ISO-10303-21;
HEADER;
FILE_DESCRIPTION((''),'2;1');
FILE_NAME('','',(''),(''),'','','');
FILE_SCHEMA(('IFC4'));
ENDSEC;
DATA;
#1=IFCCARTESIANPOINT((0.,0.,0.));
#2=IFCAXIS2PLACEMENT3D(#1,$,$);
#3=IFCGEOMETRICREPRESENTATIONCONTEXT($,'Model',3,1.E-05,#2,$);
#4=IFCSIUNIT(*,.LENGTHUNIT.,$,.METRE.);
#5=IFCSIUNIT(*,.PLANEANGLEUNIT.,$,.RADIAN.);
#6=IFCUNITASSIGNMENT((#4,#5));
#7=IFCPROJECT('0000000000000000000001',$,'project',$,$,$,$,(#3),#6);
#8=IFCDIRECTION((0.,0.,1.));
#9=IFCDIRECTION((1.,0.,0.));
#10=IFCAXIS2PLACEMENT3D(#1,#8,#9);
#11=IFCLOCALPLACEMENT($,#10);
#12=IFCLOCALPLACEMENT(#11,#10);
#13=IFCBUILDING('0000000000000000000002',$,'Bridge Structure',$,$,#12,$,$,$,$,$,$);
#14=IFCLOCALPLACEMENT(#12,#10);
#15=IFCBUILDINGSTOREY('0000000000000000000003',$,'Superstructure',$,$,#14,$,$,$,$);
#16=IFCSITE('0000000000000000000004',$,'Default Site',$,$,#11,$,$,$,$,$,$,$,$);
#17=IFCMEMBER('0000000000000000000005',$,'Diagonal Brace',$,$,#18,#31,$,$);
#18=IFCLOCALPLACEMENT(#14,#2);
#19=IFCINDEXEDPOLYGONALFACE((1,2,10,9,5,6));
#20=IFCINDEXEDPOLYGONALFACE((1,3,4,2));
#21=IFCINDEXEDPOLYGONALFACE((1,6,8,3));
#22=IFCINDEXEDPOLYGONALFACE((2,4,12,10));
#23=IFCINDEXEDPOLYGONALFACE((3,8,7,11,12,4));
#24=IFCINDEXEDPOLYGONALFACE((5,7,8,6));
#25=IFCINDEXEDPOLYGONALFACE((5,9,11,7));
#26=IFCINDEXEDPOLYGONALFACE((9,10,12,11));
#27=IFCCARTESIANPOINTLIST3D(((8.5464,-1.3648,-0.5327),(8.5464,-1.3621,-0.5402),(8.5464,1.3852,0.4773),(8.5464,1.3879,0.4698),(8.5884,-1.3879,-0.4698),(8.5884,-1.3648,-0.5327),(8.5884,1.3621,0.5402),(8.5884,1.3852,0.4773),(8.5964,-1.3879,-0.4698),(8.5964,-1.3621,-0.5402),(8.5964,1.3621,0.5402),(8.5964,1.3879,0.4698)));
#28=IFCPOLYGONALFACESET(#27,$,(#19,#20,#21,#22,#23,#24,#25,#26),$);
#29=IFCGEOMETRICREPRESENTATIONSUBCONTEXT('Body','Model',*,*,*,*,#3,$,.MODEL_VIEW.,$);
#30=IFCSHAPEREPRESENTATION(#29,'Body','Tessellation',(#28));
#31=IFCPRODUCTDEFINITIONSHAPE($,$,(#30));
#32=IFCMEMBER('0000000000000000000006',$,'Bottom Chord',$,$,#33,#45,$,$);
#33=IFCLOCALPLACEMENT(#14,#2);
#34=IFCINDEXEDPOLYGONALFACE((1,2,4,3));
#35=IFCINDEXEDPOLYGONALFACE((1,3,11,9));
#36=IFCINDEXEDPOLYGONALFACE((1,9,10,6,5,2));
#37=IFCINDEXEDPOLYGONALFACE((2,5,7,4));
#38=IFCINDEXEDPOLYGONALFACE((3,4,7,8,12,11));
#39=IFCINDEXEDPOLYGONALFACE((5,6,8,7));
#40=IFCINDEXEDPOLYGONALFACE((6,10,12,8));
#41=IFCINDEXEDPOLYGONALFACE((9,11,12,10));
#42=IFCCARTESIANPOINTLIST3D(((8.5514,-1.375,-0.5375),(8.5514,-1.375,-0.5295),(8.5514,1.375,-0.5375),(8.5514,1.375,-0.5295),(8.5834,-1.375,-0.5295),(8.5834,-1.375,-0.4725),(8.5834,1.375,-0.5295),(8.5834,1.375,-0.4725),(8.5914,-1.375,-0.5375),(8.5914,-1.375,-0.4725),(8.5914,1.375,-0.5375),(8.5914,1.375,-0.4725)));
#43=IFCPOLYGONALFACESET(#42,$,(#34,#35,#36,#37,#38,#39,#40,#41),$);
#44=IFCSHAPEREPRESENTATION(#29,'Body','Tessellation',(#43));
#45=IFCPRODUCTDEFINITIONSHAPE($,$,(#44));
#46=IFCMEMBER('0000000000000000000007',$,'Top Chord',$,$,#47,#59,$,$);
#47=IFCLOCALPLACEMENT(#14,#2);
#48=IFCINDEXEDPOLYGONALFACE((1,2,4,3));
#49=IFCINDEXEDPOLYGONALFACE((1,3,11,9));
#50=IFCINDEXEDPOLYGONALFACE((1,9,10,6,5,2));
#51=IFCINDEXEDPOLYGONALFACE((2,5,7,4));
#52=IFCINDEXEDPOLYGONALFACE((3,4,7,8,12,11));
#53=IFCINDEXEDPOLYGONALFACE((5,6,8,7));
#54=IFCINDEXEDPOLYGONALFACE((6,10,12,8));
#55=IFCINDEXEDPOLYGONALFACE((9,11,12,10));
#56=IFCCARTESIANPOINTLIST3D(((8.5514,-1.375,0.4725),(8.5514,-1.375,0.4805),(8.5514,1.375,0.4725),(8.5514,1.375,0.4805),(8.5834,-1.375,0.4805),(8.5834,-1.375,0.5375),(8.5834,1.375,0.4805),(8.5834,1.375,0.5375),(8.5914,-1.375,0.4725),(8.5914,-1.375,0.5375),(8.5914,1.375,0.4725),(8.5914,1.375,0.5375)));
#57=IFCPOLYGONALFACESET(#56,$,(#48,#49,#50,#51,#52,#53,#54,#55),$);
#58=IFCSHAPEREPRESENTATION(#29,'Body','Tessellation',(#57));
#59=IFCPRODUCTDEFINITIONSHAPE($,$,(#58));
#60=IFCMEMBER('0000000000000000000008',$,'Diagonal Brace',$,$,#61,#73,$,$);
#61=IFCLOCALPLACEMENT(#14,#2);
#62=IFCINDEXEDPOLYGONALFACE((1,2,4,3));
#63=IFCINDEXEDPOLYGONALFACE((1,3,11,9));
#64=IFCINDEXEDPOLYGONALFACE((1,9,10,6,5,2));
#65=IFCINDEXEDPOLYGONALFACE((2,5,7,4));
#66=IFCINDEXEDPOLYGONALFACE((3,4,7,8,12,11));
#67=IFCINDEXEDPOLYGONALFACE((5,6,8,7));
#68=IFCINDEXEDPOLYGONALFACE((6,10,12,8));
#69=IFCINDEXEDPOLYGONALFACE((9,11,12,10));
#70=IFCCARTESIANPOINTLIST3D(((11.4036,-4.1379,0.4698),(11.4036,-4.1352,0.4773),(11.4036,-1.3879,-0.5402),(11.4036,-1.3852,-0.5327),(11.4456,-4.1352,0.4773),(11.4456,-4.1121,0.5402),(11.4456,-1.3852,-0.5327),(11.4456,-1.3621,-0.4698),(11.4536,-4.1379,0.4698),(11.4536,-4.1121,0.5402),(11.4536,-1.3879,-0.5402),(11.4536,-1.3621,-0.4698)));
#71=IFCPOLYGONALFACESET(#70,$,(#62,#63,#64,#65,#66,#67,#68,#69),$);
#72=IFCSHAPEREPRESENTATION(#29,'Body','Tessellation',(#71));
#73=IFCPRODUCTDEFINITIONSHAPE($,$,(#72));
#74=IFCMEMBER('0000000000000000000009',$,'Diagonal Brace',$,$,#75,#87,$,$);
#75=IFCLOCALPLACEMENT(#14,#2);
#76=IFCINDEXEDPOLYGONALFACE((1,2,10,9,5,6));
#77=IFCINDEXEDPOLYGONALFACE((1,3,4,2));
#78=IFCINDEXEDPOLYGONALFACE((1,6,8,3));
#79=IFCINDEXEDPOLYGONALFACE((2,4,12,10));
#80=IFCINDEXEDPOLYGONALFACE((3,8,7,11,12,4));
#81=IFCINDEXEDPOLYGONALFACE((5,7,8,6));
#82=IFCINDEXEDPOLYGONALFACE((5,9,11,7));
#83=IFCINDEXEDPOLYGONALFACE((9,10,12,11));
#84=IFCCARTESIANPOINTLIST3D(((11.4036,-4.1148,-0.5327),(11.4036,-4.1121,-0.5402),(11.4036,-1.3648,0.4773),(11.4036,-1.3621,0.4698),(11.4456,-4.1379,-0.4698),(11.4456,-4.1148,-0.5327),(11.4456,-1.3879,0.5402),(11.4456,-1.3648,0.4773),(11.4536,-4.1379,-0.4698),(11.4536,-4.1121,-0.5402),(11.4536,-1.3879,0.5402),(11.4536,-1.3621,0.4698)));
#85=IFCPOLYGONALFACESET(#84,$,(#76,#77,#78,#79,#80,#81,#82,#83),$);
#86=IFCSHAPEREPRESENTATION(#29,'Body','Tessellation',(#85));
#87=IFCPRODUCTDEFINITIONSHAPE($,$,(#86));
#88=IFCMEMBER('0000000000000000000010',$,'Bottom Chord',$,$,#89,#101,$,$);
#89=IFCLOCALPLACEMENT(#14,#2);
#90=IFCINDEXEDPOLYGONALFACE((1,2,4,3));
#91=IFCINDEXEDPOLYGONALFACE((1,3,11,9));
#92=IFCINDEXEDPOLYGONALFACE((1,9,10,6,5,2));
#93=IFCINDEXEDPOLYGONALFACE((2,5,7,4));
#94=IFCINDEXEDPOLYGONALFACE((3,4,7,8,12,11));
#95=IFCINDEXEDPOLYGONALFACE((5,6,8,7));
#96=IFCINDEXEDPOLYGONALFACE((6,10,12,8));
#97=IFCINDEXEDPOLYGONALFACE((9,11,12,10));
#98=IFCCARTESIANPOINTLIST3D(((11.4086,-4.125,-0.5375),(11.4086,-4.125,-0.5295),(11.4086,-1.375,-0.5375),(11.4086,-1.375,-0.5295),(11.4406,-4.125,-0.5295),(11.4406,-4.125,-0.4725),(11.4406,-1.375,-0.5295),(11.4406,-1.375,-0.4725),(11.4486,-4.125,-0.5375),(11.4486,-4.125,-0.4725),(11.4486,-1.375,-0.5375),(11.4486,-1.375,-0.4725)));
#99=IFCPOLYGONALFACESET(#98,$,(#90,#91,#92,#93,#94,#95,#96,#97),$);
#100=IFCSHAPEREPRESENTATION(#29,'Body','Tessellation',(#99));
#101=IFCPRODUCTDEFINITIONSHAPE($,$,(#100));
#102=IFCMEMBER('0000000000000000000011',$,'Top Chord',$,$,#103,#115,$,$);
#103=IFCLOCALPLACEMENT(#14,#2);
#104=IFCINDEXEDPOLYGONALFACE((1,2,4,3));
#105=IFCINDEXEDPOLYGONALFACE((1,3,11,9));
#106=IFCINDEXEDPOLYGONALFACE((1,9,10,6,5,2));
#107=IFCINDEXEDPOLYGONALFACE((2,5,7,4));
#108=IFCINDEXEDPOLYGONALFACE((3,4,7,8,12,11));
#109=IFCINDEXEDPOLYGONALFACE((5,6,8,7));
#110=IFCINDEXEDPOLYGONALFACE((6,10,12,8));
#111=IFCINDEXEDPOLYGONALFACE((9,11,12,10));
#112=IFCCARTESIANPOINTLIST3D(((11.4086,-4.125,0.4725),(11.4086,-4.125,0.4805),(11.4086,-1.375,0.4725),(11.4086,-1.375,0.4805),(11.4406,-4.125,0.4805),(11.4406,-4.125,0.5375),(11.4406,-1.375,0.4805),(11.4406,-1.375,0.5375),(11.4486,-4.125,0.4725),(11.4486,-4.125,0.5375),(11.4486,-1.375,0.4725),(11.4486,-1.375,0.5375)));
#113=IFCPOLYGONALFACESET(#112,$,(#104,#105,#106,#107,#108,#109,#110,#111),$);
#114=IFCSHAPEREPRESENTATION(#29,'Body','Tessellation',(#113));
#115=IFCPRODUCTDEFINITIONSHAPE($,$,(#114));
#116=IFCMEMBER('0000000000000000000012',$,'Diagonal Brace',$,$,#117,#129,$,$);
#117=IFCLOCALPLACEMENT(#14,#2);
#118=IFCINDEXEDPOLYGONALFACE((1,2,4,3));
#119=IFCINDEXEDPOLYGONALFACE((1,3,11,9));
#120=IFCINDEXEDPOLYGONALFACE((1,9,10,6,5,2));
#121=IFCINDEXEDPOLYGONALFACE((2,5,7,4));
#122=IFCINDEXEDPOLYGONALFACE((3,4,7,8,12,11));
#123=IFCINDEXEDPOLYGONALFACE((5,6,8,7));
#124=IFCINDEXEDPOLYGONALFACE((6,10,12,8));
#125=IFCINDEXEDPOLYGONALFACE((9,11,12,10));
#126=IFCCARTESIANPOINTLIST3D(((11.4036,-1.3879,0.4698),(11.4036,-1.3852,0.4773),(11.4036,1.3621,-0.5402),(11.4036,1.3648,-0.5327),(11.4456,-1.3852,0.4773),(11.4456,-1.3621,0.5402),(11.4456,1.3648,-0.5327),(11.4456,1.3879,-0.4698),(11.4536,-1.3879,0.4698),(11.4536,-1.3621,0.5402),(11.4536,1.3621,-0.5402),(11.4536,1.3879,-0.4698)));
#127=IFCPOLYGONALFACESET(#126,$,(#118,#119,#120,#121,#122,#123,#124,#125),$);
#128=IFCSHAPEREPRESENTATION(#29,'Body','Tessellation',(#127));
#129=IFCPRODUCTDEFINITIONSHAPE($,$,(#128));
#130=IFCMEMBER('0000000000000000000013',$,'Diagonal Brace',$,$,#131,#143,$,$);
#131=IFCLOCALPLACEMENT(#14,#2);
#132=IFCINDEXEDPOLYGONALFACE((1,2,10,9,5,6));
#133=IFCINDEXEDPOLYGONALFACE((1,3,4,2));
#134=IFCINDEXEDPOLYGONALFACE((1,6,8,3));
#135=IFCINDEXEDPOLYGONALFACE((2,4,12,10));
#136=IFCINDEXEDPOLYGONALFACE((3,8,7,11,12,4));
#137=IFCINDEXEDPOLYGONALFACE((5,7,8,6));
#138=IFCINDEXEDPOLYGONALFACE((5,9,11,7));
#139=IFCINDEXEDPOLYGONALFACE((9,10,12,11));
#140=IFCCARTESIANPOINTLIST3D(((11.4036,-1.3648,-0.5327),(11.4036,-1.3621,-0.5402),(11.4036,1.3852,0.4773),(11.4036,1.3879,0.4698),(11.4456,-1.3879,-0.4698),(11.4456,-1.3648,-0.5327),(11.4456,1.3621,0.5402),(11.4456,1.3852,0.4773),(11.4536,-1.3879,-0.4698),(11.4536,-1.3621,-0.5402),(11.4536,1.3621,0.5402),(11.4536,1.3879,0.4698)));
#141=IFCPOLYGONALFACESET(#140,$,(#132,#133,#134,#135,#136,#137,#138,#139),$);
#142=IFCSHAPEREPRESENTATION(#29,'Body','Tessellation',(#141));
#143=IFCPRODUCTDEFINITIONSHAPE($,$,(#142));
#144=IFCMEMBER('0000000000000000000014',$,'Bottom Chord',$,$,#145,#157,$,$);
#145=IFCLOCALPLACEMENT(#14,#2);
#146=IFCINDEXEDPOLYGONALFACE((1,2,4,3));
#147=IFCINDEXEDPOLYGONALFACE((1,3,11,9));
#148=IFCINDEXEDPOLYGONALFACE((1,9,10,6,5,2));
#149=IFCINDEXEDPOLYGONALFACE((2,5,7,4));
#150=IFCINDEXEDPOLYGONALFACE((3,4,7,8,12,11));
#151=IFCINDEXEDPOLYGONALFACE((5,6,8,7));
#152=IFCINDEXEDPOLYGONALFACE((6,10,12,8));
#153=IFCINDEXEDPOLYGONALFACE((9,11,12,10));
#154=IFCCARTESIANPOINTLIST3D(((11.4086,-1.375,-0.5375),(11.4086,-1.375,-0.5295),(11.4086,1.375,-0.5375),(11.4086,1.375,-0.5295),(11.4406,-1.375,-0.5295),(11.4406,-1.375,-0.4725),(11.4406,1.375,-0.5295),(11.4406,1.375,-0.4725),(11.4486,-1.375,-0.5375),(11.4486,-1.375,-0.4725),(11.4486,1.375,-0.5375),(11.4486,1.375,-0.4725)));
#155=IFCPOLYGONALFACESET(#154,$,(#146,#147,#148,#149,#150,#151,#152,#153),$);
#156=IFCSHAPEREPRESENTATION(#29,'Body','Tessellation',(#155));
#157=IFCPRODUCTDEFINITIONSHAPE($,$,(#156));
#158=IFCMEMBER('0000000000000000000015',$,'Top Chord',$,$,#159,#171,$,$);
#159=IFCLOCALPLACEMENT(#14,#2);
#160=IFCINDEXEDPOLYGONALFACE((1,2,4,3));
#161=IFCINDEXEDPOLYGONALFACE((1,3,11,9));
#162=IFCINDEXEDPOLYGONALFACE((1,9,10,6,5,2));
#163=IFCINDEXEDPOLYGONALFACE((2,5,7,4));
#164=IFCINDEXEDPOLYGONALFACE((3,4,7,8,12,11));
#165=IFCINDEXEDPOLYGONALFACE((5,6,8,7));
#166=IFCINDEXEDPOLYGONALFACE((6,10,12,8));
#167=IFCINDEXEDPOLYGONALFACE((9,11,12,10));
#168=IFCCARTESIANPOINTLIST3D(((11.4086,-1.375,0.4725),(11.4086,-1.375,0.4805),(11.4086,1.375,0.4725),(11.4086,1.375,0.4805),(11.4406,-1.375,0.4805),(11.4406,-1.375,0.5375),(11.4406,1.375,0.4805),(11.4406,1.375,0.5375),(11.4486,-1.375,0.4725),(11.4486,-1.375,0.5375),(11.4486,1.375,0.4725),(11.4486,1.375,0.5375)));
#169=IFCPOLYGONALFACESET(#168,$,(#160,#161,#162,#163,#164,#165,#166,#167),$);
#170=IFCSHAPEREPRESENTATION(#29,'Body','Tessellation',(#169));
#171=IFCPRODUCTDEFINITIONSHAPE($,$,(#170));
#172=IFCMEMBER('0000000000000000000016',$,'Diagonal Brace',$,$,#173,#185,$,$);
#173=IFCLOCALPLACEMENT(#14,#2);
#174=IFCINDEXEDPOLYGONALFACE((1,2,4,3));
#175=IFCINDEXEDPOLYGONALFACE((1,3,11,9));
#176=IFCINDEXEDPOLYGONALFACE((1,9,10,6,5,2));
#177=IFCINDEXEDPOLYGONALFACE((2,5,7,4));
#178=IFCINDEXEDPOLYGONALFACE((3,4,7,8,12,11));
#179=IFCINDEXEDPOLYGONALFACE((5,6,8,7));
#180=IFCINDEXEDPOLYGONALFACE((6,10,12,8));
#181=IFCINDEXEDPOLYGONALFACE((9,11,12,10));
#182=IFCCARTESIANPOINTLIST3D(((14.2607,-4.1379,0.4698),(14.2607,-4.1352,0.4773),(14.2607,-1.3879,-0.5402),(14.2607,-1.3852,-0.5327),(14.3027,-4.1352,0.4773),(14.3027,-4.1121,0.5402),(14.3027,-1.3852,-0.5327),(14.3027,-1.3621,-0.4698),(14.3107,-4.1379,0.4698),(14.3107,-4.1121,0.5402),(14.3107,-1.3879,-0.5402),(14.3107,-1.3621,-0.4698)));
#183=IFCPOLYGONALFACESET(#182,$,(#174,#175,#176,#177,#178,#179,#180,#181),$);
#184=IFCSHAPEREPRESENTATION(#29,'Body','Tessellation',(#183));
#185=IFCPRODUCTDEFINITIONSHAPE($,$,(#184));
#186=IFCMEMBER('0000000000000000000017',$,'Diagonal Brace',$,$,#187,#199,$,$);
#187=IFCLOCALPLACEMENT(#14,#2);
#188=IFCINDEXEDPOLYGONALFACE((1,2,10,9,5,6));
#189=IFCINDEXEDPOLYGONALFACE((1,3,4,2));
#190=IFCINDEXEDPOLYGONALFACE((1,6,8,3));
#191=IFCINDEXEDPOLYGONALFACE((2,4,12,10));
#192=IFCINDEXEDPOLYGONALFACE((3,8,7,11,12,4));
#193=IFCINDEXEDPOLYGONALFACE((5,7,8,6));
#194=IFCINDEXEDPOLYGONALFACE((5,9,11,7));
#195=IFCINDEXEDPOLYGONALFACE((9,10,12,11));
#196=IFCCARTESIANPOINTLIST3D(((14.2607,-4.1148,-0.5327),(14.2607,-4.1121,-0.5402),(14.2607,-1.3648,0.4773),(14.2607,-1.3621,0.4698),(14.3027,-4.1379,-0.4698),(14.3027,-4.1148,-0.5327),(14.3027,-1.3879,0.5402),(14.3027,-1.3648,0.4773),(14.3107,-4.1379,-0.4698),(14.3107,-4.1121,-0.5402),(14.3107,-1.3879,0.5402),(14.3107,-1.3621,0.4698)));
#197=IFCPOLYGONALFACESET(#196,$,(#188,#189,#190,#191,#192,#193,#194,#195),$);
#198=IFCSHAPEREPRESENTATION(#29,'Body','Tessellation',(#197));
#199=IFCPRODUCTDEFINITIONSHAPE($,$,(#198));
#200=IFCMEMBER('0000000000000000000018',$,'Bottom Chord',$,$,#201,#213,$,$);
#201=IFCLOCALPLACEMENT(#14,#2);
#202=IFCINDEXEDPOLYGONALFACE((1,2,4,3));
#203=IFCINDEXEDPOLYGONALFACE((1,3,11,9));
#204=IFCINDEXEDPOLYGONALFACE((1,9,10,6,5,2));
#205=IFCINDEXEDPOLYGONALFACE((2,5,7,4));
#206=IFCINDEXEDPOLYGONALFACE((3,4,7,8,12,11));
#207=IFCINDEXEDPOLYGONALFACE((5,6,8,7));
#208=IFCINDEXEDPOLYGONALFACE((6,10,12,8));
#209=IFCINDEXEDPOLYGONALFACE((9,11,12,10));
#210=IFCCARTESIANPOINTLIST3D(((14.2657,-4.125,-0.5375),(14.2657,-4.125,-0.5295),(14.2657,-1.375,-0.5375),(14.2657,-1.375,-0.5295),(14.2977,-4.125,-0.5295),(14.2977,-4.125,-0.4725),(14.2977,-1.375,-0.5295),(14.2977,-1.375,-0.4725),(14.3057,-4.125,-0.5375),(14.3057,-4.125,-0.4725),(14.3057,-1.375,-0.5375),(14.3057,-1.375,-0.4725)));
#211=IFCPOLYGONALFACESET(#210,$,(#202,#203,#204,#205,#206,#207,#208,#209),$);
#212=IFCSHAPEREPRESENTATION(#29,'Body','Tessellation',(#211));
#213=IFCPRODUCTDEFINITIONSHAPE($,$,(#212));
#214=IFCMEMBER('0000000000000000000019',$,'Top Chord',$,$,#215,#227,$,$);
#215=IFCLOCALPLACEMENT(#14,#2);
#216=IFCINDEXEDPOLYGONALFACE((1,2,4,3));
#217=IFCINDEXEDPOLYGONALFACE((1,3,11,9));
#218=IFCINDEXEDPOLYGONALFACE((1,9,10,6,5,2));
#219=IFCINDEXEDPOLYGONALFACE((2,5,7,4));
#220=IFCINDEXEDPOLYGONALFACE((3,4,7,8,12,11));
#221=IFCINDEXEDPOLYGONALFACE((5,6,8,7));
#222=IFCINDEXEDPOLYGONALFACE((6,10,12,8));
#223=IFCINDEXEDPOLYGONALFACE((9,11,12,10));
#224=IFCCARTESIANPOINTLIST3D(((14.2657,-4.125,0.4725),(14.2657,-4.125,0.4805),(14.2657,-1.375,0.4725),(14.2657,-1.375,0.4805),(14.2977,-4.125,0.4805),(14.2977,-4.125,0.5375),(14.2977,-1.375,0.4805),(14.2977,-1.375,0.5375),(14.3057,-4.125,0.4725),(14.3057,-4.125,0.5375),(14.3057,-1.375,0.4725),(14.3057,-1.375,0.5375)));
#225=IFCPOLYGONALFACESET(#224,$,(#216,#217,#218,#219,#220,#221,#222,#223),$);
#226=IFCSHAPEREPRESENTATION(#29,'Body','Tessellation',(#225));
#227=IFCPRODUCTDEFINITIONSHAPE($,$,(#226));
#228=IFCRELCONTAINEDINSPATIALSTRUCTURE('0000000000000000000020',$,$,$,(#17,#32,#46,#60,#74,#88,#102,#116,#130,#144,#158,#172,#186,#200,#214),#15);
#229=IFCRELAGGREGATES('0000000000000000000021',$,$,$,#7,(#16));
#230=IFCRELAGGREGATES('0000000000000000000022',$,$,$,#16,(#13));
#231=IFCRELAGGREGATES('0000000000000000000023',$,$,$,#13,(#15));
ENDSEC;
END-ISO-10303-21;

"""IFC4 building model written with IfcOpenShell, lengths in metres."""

from ifc_helpers import new_model, si_unit, frame, origin, origin_with_axes, origin_2d_with_axis, place, context, subcontext, project, spatial, l_section, extrude, element, save


model = new_model("IFC4")

# Units and contexts
model_context = context("Model", 3, precision=1e-05, world=origin())
body_context = subcontext(model_context, "Body", "Model", "MODEL_VIEW")
ifc_project = project(units=[si_unit("LENGTHUNIT", "METRE"), si_unit("PLANEANGLEUNIT", "RADIAN")], contexts=[model_context])

# Site, building, storey
site_placement = place(None, origin_with_axes())
site = spatial("IfcSite", under=ifc_project, at=site_placement, Name="Default Site")
building_placement = place(site_placement, origin_with_axes())
building = spatial("IfcBuilding", under=site, at=building_placement, Name="Bridge Structure")
storey_placement = place(building_placement, origin_with_axes())
storey = spatial("IfcBuildingStorey", under=building, at=storey_placement, Name="Superstructure")

# Members
member_placement = place(storey_placement, frame((8.5714, -1.375, -0.505), z_axis=(0.0, 0.938692, 0.344756), x_axis=(-1.0, 0.0, 0.0)))
element("IfcMember", 1, at=member_placement, inside=storey, Name="Diagonal Brace", context=body_context, shape_type="SweptSolid", body=[
    extrude(l_section(Depth=0.075, Width=0.05, Thickness=0.008, at=origin_2d_with_axis()), origin_with_axes(), (0.0, 0.0, 1.0), 2.9296),
])
for number, where, z_axis, x_axis, name in (
    (2, (8.5714, -1.375, -0.505), (0.0, 1.0, 0.0), (-1.0, 0.0, 0.0), "Bottom Chord"),
    (3, (8.5714, -1.375, 0.505), (0.0, 1.0, 0.0), (-1.0, 0.0, 0.0), "Top Chord"),
):
    element("IfcMember", number, at=place(storey_placement, frame(where, z_axis=z_axis, x_axis=x_axis)), inside=storey, Name=name, context=body_context, shape_type="SweptSolid", body=[
        extrude(l_section(Depth=0.065, Width=0.04, Thickness=0.008, at=origin_2d_with_axis()), origin_with_axes(), (0.0, 0.0, 1.0), 2.75),
    ])
for number, where, z_axis, x_axis, name in (
    (4, (11.4286, -4.125, 0.505), (0.0, 0.938692, -0.344756), (-1.0, 0.0, 0.0), "Diagonal Brace"),
    (5, (11.4286, -4.125, -0.505), (0.0, 0.938692, 0.344756), (-1.0, 0.0, 0.0), "Diagonal Brace"),
):
    element("IfcMember", number, at=place(storey_placement, frame(where, z_axis=z_axis, x_axis=x_axis)), inside=storey, Name=name, context=body_context, shape_type="SweptSolid", body=[
        extrude(l_section(Depth=0.075, Width=0.05, Thickness=0.008, at=origin_2d_with_axis()), origin_with_axes(), (0.0, 0.0, 1.0), 2.9296),
    ])
for number, where, z_axis, x_axis, name in (
    (6, (11.4286, -4.125, -0.505), (0.0, 1.0, 0.0), (-1.0, 0.0, 0.0), "Bottom Chord"),
    (7, (11.4286, -4.125, 0.505), (0.0, 1.0, 0.0), (-1.0, 0.0, 0.0), "Top Chord"),
):
    element("IfcMember", number, at=place(storey_placement, frame(where, z_axis=z_axis, x_axis=x_axis)), inside=storey, Name=name, context=body_context, shape_type="SweptSolid", body=[
        extrude(l_section(Depth=0.065, Width=0.04, Thickness=0.008, at=origin_2d_with_axis()), origin_with_axes(), (0.0, 0.0, 1.0), 2.75),
    ])
for number, where, z_axis, x_axis, name in (
    (8, (11.4286, -1.375, 0.505), (0.0, 0.938692, -0.344756), (-1.0, 0.0, 0.0), "Diagonal Brace"),
    (9, (11.4286, -1.375, -0.505), (0.0, 0.938692, 0.344756), (-1.0, 0.0, 0.0), "Diagonal Brace"),
):
    element("IfcMember", number, at=place(storey_placement, frame(where, z_axis=z_axis, x_axis=x_axis)), inside=storey, Name=name, context=body_context, shape_type="SweptSolid", body=[
        extrude(l_section(Depth=0.075, Width=0.05, Thickness=0.008, at=origin_2d_with_axis()), origin_with_axes(), (0.0, 0.0, 1.0), 2.9296),
    ])
for number, where, z_axis, x_axis, name in (
    (10, (11.4286, -1.375, -0.505), (0.0, 1.0, 0.0), (-1.0, 0.0, 0.0), "Bottom Chord"),
    (11, (11.4286, -1.375, 0.505), (0.0, 1.0, 0.0), (-1.0, 0.0, 0.0), "Top Chord"),
):
    element("IfcMember", number, at=place(storey_placement, frame(where, z_axis=z_axis, x_axis=x_axis)), inside=storey, Name=name, context=body_context, shape_type="SweptSolid", body=[
        extrude(l_section(Depth=0.065, Width=0.04, Thickness=0.008, at=origin_2d_with_axis()), origin_with_axes(), (0.0, 0.0, 1.0), 2.75),
    ])
for number, where, z_axis, x_axis, name in (
    (12, (14.2857, -4.125, 0.505), (0.0, 0.938692, -0.344756), (-1.0, 0.0, 0.0), "Diagonal Brace"),
    (13, (14.2857, -4.125, -0.505), (0.0, 0.938692, 0.344756), (-1.0, 0.0, 0.0), "Diagonal Brace"),
):
    element("IfcMember", number, at=place(storey_placement, frame(where, z_axis=z_axis, x_axis=x_axis)), inside=storey, Name=name, context=body_context, shape_type="SweptSolid", body=[
        extrude(l_section(Depth=0.075, Width=0.05, Thickness=0.008, at=origin_2d_with_axis()), origin_with_axes(), (0.0, 0.0, 1.0), 2.9296),
    ])
for number, where, z_axis, x_axis, name in (
    (14, (14.2857, -4.125, -0.505), (0.0, 1.0, 0.0), (-1.0, 0.0, 0.0), "Bottom Chord"),
    (15, (14.2857, -4.125, 0.505), (0.0, 1.0, 0.0), (-1.0, 0.0, 0.0), "Top Chord"),
):
    element("IfcMember", number, at=place(storey_placement, frame(where, z_axis=z_axis, x_axis=x_axis)), inside=storey, Name=name, context=body_context, shape_type="SweptSolid", body=[
        extrude(l_section(Depth=0.065, Width=0.04, Thickness=0.008, at=origin_2d_with_axis()), origin_with_axes(), (0.0, 0.0, 1.0), 2.75),
    ])

save(model, "model.ifc")
